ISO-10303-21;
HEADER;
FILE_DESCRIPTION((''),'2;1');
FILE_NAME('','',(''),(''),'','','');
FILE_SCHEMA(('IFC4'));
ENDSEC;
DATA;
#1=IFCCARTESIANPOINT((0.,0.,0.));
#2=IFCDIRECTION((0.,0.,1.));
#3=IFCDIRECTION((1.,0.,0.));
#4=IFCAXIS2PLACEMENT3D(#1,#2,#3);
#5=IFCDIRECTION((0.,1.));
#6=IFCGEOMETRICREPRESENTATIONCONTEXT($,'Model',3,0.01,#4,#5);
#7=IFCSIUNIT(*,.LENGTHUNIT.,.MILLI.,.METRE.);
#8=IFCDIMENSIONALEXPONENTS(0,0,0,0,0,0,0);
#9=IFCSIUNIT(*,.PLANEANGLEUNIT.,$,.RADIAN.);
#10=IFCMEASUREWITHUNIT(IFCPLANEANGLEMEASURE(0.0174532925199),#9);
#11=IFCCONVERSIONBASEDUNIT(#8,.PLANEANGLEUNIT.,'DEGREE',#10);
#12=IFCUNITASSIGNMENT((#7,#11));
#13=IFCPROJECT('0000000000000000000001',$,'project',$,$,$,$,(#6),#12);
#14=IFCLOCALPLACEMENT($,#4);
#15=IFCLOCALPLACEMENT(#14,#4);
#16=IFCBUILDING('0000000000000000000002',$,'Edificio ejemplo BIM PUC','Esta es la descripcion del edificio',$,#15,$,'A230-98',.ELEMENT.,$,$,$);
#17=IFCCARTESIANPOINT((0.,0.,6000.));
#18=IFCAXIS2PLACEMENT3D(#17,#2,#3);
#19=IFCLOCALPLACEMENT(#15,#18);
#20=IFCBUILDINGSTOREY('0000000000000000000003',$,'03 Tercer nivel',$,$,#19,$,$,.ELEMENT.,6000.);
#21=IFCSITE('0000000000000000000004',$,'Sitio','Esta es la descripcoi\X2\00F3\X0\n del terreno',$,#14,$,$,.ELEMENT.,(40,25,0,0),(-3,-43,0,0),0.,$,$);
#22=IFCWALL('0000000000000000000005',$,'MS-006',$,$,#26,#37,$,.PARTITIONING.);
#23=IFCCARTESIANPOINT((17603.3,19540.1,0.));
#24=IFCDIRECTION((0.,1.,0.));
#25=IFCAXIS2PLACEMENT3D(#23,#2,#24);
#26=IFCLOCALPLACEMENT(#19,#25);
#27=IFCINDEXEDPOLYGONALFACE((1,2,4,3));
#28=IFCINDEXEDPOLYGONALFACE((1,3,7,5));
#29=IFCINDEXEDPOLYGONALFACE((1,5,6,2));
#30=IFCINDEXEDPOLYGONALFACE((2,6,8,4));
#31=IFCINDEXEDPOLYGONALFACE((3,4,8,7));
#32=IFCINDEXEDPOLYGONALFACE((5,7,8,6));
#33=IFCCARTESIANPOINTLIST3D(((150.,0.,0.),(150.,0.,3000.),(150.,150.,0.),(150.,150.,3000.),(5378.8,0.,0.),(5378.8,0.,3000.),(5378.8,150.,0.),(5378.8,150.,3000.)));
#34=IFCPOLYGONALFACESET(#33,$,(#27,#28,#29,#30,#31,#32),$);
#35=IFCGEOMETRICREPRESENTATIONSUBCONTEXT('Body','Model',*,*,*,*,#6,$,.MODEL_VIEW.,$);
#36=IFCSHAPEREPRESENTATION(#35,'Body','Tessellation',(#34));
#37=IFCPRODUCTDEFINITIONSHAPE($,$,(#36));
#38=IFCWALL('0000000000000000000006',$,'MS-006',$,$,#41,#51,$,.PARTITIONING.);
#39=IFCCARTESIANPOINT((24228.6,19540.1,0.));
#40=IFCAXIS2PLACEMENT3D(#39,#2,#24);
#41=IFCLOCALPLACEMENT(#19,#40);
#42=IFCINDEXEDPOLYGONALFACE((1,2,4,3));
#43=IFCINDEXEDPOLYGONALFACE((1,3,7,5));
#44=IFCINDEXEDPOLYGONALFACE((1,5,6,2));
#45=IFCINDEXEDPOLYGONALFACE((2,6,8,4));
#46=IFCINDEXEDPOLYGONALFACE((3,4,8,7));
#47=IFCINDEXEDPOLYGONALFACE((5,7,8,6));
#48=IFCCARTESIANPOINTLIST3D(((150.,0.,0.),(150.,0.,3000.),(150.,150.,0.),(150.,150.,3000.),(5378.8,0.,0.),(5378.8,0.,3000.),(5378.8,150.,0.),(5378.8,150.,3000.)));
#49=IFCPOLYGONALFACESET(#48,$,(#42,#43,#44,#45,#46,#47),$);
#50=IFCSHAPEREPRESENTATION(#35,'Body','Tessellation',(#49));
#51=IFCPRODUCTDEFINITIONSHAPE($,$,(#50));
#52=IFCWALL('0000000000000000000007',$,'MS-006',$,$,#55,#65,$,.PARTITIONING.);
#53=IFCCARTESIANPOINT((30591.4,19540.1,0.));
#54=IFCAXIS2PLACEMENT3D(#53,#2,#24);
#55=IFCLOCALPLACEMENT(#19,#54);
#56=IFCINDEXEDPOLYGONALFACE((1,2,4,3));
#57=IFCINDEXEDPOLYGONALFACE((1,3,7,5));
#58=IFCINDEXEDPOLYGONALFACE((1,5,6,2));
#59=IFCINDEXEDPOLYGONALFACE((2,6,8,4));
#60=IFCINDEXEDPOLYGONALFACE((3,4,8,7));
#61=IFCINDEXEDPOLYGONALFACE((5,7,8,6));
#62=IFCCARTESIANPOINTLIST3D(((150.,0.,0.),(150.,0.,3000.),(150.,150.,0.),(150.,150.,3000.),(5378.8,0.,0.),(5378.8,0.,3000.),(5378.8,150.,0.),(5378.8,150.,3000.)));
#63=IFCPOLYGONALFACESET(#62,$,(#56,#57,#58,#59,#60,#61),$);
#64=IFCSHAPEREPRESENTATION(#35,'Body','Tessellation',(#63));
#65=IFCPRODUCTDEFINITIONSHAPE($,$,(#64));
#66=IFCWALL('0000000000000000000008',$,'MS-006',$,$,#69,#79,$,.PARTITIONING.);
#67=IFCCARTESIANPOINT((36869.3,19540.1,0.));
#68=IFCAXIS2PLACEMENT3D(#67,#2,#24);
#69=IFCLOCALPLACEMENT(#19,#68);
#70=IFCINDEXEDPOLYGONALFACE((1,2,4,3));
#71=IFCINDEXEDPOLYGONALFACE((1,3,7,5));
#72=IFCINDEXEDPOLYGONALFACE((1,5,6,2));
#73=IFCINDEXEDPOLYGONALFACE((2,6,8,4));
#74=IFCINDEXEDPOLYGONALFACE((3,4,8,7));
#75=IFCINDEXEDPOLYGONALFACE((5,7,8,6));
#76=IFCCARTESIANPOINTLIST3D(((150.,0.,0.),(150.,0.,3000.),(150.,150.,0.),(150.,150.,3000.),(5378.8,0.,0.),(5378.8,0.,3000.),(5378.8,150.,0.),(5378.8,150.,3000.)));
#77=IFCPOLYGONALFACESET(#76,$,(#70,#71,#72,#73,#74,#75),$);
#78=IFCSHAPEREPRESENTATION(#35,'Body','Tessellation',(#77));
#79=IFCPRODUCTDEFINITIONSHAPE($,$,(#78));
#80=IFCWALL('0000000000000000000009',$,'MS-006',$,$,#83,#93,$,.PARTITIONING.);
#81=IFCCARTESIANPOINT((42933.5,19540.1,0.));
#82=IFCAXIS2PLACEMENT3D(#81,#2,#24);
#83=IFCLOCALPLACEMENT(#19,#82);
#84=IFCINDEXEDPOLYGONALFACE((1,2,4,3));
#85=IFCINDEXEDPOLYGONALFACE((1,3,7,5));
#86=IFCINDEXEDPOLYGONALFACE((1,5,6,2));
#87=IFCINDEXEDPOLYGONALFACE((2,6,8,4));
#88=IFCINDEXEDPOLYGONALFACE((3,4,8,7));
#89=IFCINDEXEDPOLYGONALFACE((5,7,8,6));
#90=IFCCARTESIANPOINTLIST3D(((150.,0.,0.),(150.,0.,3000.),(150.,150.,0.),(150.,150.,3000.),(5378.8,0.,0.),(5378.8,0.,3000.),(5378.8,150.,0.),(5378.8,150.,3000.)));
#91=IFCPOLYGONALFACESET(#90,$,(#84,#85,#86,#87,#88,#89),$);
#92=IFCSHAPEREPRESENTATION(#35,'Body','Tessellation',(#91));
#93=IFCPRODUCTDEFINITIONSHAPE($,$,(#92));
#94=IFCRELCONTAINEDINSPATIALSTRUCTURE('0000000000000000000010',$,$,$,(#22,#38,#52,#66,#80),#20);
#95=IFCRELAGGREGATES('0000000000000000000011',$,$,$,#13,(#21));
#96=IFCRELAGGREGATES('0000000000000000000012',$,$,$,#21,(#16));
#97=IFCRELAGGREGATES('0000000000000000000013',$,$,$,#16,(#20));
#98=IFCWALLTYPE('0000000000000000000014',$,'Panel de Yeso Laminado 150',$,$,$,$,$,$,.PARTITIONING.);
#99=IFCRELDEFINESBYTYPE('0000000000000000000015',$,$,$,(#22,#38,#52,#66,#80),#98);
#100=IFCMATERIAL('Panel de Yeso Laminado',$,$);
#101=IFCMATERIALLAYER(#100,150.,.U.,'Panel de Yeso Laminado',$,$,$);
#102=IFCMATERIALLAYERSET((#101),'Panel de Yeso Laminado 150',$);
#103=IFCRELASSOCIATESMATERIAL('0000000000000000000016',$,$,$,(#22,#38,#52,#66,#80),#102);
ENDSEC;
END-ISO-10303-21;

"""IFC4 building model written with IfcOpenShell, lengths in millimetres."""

from ifc_helpers import new_model, entity, si_unit, converted_unit, direction, frame, origin_with_axes, place, context, subcontext, project, spatial, line, indexed_curve, outline, extrude, material, layer, layer_set, layer_usage, type_object, element, save


model = new_model("IFC4")

# Units and contexts
model_context = context("Model", 3, precision=0.01, world=origin_with_axes(), true_north=direction((0.0, 1.0)))
body_context = subcontext(model_context, "Body", "Model", "MODEL_VIEW")
ifc_project = project(units=[si_unit("LENGTHUNIT", "METRE", prefix="MILLI"), converted_unit("PLANEANGLEUNIT", "DEGREE", entity("IfcPlaneAngleMeasure", 0.0174532925199), si_unit("PLANEANGLEUNIT", "RADIAN"), dimensions=[0, 0, 0, 0, 0, 0, 0])], contexts=[model_context])

# Site, building, storey
site_placement = place(None, origin_with_axes())
site = spatial("IfcSite", under=ifc_project, at=site_placement, Name="Sitio", Description="Esta es la descripcoión del terreno", CompositionType="ELEMENT", RefLatitude=(40, 25, 0, 0), RefLongitude=(-3, -43, 0, 0), RefElevation=0.0)
building_placement = place(site_placement, origin_with_axes())
building = spatial("IfcBuilding", under=site, at=building_placement, Name="Edificio ejemplo BIM PUC", Description="Esta es la descripcion del edificio", LongName="A230-98", CompositionType="ELEMENT")
storey_placement = place(building_placement, frame((0.0, 0.0, 6000.0), z_axis=(0.0, 0.0, 1.0), x_axis=(1.0, 0.0, 0.0)))
storey = spatial("IfcBuildingStorey", under=building, at=storey_placement, Name="03 Tercer nivel", CompositionType="ELEMENT", Elevation=6000.0)

# Walls
ifc_material_1 = material(Name="Panel de Yeso Laminado")
ifc_layer_1 = layer(ifc_material_1, 150.0, ventilated="UNKNOWN", Name="Panel de Yeso Laminado")
ifc_layer_set_1 = layer_set([ifc_layer_1], Name="Panel de Yeso Laminado 150")
ifc_layer_usage_1 = layer_usage(ifc_layer_set_1, "AXIS2", "POSITIVE", 0.0)
wall_type_1 = type_object("IfcWallType", Name="Panel de Yeso Laminado 150", PredefinedType="PARTITIONING")
wall_1_placement = place(storey_placement, frame((17603.3, 19540.1, 0.0), z_axis=(0.0, 0.0, 1.0), x_axis=(0.0, 1.0, 0.0)))
element("IfcWall", 1, at=wall_1_placement, inside=storey, type_object=wall_type_1, material=ifc_layer_usage_1, Name="MS-006", PredefinedType="PARTITIONING", context=body_context, shape_type="SweptSolid", body=[
    extrude(outline(indexed_curve([(150.0, 0.0), (5378.8, 0.0), (5378.8, 150.0), (150.0, 150.0)], segments=[line(1, 2, 3, 4, 1)])), origin_with_axes(), (0.0, 0.0, 1.0), 3000.0),
])
ifc_layer_usage_2 = layer_usage(ifc_layer_set_1, "AXIS2", "POSITIVE", 0.0)
wall_2_placement = place(storey_placement, frame((24228.6, 19540.1, 0.0), z_axis=(0.0, 0.0, 1.0), x_axis=(0.0, 1.0, 0.0)))
element("IfcWall", 2, at=wall_2_placement, inside=storey, type_object=wall_type_1, material=ifc_layer_usage_2, Name="MS-006", PredefinedType="PARTITIONING", context=body_context, shape_type="SweptSolid", body=[
    extrude(outline(indexed_curve([(150.0, 0.0), (5378.8, 0.0), (5378.8, 150.0), (150.0, 150.0)], segments=[line(1, 2, 3, 4, 1)])), origin_with_axes(), (0.0, 0.0, 1.0), 3000.0),
])
ifc_layer_usage_3 = layer_usage(ifc_layer_set_1, "AXIS2", "POSITIVE", 0.0)
wall_3_placement = place(storey_placement, frame((30591.4, 19540.1, 0.0), z_axis=(0.0, 0.0, 1.0), x_axis=(0.0, 1.0, 0.0)))
element("IfcWall", 3, at=wall_3_placement, inside=storey, type_object=wall_type_1, material=ifc_layer_usage_3, Name="MS-006", PredefinedType="PARTITIONING", context=body_context, shape_type="SweptSolid", body=[
    extrude(outline(indexed_curve([(150.0, 0.0), (5378.8, 0.0), (5378.8, 150.0), (150.0, 150.0)], segments=[line(1, 2, 3, 4, 1)])), origin_with_axes(), (0.0, 0.0, 1.0), 3000.0),
])
ifc_layer_usage_4 = layer_usage(ifc_layer_set_1, "AXIS2", "POSITIVE", 0.0)
wall_4_placement = place(storey_placement, frame((36869.3, 19540.1, 0.0), z_axis=(0.0, 0.0, 1.0), x_axis=(0.0, 1.0, 0.0)))
element("IfcWall", 4, at=wall_4_placement, inside=storey, type_object=wall_type_1, material=ifc_layer_usage_4, Name="MS-006", PredefinedType="PARTITIONING", context=body_context, shape_type="SweptSolid", body=[
    extrude(outline(indexed_curve([(150.0, 0.0), (5378.8, 0.0), (5378.8, 150.0), (150.0, 150.0)], segments=[line(1, 2, 3, 4, 1)])), origin_with_axes(), (0.0, 0.0, 1.0), 3000.0),
])
ifc_layer_usage_5 = layer_usage(ifc_layer_set_1, "AXIS2", "POSITIVE", 0.0)
wall_5_placement = place(storey_placement, frame((42933.5, 19540.1, 0.0), z_axis=(0.0, 0.0, 1.0), x_axis=(0.0, 1.0, 0.0)))
element("IfcWall", 5, at=wall_5_placement, inside=storey, type_object=wall_type_1, material=ifc_layer_usage_5, Name="MS-006", PredefinedType="PARTITIONING", context=body_context, shape_type="SweptSolid", body=[
    extrude(outline(indexed_curve([(150.0, 0.0), (5378.8, 0.0), (5378.8, 150.0), (150.0, 150.0)], segments=[line(1, 2, 3, 4, 1)])), origin_with_axes(), (0.0, 0.0, 1.0), 3000.0),
])

save(model, "model.ifc")
